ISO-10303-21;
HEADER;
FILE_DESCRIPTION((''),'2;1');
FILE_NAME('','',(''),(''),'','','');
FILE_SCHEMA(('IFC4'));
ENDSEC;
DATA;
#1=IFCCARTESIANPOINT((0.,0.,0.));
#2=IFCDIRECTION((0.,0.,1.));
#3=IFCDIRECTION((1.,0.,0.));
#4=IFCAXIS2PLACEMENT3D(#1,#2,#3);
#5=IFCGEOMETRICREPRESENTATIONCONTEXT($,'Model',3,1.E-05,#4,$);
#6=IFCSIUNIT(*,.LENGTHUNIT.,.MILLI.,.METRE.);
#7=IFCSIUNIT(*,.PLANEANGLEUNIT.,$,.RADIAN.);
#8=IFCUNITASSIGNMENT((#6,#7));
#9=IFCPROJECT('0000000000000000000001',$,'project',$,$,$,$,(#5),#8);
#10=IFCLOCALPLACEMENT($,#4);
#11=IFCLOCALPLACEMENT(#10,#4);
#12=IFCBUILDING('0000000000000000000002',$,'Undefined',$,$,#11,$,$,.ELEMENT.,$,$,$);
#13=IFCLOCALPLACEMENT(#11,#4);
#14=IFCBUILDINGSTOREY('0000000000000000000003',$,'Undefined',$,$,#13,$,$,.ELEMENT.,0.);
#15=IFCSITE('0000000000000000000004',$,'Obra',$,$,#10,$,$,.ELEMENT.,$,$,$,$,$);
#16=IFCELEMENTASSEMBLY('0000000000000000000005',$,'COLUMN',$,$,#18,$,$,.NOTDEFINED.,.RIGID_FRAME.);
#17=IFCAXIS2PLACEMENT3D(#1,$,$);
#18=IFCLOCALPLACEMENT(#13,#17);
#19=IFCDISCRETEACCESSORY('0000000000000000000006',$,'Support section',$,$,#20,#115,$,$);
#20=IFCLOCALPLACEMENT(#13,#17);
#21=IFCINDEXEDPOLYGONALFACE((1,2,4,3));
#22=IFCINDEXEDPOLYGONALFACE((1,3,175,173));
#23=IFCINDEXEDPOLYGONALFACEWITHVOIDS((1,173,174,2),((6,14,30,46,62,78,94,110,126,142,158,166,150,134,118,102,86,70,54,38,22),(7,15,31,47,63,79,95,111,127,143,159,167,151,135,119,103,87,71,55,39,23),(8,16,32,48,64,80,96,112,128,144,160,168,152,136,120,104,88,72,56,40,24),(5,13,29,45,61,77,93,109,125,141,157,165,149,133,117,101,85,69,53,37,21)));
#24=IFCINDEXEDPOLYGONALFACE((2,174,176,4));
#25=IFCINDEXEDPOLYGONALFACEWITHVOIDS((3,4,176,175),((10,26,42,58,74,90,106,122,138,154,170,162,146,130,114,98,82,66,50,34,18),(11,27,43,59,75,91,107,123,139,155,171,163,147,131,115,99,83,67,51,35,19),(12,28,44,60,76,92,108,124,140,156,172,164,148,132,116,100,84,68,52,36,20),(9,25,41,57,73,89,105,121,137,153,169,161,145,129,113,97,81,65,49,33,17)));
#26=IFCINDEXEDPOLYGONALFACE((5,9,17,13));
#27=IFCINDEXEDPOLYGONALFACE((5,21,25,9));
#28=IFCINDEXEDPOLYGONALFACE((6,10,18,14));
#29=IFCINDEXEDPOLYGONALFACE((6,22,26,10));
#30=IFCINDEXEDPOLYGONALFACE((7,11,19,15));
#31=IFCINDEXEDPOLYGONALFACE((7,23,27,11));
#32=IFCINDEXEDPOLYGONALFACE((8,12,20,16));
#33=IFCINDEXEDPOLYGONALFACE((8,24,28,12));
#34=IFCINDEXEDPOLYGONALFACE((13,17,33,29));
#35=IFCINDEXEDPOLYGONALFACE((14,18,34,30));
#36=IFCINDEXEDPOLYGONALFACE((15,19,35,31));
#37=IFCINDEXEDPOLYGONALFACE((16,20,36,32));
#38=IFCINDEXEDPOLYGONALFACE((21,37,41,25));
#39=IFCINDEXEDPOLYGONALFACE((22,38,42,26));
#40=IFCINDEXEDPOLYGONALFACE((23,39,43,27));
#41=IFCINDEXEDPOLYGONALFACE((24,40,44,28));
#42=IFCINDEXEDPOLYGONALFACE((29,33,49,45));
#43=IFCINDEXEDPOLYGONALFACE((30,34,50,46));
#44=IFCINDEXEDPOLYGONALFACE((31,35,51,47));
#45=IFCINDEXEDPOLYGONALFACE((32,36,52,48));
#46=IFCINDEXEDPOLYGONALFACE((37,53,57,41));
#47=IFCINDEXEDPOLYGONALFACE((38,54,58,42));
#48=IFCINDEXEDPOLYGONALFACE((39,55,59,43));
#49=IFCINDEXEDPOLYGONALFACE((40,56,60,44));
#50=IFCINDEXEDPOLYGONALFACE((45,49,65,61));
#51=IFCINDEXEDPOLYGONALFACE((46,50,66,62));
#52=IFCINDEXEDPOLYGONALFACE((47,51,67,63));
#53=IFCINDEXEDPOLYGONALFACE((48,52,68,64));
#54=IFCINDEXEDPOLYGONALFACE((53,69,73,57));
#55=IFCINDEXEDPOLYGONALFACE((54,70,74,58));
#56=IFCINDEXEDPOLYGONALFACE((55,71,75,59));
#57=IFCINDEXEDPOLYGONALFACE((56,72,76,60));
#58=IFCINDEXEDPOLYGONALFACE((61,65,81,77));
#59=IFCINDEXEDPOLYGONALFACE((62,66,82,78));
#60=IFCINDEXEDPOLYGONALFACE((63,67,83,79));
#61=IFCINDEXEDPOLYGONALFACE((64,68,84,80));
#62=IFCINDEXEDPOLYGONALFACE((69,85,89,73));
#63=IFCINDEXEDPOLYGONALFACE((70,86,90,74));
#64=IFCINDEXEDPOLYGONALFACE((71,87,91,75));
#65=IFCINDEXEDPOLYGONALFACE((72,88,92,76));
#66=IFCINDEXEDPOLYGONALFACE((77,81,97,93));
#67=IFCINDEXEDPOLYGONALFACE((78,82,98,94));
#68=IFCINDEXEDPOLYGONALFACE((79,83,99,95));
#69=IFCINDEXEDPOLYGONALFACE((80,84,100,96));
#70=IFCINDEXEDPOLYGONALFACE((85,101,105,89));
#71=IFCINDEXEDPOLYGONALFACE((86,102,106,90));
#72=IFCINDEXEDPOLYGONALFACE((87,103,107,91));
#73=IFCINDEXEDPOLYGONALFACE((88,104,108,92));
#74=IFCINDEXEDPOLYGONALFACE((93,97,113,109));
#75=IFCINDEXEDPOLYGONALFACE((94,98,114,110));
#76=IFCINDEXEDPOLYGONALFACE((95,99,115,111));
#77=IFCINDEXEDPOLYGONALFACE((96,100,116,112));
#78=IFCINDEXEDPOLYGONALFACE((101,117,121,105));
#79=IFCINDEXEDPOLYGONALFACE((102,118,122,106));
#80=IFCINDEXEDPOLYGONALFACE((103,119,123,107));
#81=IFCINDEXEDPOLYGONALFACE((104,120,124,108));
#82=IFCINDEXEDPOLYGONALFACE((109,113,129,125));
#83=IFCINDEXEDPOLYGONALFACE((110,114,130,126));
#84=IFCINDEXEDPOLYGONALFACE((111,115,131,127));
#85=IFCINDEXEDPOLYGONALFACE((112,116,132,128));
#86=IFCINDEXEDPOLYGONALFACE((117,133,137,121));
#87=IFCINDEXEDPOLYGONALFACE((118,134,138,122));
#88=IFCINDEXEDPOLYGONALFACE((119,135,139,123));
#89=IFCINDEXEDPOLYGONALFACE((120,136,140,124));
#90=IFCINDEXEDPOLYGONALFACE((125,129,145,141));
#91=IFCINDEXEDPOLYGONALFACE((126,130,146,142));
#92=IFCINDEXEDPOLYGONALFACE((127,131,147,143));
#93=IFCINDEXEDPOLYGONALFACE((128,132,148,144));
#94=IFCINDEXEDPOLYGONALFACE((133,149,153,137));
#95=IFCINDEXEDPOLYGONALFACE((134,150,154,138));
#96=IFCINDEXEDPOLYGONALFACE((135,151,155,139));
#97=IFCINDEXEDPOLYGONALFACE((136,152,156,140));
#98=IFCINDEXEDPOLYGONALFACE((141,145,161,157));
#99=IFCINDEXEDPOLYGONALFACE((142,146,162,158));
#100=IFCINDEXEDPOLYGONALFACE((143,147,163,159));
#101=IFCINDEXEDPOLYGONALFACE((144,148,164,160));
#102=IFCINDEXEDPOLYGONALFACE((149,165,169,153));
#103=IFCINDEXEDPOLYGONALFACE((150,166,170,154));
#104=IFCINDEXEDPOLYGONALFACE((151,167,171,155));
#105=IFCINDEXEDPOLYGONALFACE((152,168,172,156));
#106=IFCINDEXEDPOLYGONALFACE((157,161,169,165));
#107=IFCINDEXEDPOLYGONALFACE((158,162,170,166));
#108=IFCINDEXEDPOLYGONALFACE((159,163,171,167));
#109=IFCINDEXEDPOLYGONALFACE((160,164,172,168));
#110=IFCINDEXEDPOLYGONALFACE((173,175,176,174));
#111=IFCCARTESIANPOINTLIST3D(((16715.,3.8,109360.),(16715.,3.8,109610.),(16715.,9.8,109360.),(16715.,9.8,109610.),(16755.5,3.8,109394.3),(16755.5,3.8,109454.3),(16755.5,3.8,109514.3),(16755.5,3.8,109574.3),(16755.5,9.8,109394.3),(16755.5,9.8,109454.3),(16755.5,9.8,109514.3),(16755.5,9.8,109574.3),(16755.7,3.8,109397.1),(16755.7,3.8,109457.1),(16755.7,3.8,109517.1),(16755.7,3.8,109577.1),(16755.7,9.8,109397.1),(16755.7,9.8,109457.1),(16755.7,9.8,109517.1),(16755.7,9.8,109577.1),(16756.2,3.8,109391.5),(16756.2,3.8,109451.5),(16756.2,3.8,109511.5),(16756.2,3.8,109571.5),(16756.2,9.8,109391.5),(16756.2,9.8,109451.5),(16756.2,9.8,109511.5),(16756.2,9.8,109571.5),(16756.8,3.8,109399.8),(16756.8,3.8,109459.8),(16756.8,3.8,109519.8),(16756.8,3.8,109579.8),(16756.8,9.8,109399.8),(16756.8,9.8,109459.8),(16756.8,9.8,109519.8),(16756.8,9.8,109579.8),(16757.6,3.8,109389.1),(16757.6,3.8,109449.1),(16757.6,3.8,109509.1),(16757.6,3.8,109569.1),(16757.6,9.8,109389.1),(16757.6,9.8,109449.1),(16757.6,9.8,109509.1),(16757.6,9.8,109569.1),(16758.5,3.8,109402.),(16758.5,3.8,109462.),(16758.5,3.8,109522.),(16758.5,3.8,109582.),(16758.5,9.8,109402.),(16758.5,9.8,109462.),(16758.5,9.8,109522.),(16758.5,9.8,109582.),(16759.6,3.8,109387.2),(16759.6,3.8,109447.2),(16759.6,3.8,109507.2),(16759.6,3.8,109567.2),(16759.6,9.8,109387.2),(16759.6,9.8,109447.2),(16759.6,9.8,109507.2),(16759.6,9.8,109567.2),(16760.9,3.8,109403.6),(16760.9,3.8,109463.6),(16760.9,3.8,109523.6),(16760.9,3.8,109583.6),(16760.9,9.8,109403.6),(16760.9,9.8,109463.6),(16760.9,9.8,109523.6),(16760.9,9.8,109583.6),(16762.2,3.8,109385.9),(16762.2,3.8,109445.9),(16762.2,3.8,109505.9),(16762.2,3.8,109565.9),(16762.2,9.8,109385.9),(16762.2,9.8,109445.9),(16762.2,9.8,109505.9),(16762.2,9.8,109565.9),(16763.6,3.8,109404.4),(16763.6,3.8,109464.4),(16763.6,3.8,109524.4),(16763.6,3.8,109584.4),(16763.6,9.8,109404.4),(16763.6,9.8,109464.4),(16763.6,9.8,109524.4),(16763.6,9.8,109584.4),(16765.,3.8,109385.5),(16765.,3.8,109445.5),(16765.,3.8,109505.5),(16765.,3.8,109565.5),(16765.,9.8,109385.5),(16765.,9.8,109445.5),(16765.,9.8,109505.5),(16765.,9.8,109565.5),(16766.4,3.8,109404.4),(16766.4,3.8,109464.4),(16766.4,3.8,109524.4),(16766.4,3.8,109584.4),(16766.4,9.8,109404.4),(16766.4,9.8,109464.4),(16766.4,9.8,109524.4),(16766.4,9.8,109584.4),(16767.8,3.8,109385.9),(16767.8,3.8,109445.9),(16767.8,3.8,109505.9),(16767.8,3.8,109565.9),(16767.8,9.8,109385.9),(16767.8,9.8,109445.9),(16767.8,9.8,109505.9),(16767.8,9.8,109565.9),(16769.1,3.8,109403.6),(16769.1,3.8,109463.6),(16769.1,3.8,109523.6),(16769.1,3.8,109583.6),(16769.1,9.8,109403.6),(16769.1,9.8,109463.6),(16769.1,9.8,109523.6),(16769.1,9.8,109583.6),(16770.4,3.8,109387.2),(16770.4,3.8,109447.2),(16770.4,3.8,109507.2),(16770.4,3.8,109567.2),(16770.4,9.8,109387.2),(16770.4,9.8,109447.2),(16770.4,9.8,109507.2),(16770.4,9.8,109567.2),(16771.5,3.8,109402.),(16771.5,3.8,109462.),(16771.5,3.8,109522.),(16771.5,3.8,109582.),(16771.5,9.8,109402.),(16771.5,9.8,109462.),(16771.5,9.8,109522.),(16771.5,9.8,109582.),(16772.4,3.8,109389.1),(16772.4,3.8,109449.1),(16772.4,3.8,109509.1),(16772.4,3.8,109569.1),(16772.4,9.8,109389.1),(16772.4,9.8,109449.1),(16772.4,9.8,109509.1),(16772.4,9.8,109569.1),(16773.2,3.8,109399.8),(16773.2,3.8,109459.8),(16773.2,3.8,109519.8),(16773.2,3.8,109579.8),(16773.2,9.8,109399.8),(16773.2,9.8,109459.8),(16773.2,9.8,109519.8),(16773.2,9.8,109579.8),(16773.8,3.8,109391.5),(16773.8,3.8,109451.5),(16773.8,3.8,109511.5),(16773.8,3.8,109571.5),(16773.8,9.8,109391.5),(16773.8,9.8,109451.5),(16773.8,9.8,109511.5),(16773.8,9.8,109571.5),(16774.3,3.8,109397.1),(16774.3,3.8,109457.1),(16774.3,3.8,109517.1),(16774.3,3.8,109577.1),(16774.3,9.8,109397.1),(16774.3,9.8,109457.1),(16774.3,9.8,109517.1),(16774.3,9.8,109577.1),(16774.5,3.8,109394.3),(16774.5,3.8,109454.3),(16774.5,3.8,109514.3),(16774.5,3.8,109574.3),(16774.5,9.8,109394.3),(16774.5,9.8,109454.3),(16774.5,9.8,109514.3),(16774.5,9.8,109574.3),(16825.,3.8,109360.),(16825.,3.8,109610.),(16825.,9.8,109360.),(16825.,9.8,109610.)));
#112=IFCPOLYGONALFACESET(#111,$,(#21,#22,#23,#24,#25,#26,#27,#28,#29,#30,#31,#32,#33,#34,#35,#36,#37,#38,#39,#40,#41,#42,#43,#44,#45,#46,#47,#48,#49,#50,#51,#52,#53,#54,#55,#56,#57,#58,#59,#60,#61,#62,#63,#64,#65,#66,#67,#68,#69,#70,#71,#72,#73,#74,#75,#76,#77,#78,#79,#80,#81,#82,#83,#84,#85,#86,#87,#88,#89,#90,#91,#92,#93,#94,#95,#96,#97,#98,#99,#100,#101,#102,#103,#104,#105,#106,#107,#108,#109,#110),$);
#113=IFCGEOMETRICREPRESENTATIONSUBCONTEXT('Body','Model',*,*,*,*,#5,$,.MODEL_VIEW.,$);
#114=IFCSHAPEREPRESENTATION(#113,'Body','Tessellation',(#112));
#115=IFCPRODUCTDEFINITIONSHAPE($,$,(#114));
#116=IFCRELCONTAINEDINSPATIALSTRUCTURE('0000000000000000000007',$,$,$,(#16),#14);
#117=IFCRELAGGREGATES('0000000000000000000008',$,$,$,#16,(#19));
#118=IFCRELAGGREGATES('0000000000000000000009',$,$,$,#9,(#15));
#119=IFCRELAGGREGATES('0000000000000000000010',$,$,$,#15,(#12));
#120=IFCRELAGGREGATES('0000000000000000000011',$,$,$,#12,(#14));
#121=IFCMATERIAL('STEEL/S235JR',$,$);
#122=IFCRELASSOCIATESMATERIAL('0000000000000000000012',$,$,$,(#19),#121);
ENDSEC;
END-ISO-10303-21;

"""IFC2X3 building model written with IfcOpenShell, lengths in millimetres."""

from ifc_helpers import new_model, si_unit, frame, origin_with_axes, origin_2d_with_axis, place, context, subcontext, project, spatial, rectangle, circle, extrude, source, transform, mapped, material, element, aggregate, save


model = new_model("IFC2X3")

# Units and contexts
model_context = context("Model", 3, precision=1e-05, world=origin_with_axes())
body_context = subcontext(model_context, "Body", "Model", "MODEL_VIEW")
ifc_project = project(units=[si_unit("LENGTHUNIT", "METRE", prefix="MILLI"), si_unit("PLANEANGLEUNIT", "RADIAN")], contexts=[model_context])

# Site, building, storey
site_placement = place(None, origin_with_axes())
site = spatial("IfcSite", under=ifc_project, at=site_placement, Name="Obra", CompositionType="ELEMENT")
building_placement = place(site_placement, origin_with_axes())
building = spatial("IfcBuilding", under=site, at=building_placement, Name="Undefined", CompositionType="ELEMENT")
storey_placement = place(building_placement, origin_with_axes())
storey = spatial("IfcBuildingStorey", under=building, at=storey_placement, Name="Undefined", CompositionType="ELEMENT", Elevation=0.0)

# Element assembly, discrete accessory, opening
assembly_1_placement = place(storey_placement, origin_with_axes())
assembly_1 = element("IfcElementAssembly", 1, at=assembly_1_placement, inside=storey, Name="COLUMN", AssemblyPlace="NOTDEFINED", PredefinedType="RIGID_FRAME")
ifc_material_1 = material(Name="STEEL/S235JR")
shared_shape_1 = source(origin_with_axes(), body_context, "Body", "SweptSolid", [
    extrude(circle(Radius=9.5, at=origin_2d_with_axis()), frame((0.0, -9.8, 0.0), z_axis=(0.0, 1.0, 0.0), x_axis=(1.0, 0.0, 0.0)), (0.0, 0.0, 1.0), 6.2),
])
discrete_accessory_1_placement = place(assembly_1_placement, frame((16770.0, 6.8, 109360.0), z_axis=(0.0, 0.0, 1.0), x_axis=(1.0, 0.0, 0.0)))
discrete_accessory_1 = element("IfcDiscreteAccessory", 2, at=discrete_accessory_1_placement, material=ifc_material_1, Name="Support section", context=body_context, shape_type="SweptSolid", body=[
    extrude(rectangle(XDim=6.0, YDim=110.0, at=origin_2d_with_axis()), frame((0.0, 0.0, 250.0), z_axis=(0.0, 0.0, -1.0), x_axis=(0.0, 1.0, 0.0)), (0.0, 0.0, 1.0), 250.0),
])
opening_1_placement = place(assembly_1_placement, frame((16815.0, 0.0, 109650.0), z_axis=(-1.0, 0.0, 0.0), x_axis=(0.0, 0.0, -1.0)))
element("IfcOpeningElement", 3, at=opening_1_placement, cuts=discrete_accessory_1, ObjectType="Opening", context=body_context, shape_type="MappedRepresentation", body=[
    mapped(shared_shape_1, transform((75.0, 0.0, 50.0))),
    mapped(shared_shape_1, transform((135.0, 0.0, 50.0))),
    mapped(shared_shape_1, transform((195.0, 0.0, 50.0))),
    mapped(shared_shape_1, transform((255.0, 0.0, 50.0))),
])
aggregate(assembly_1, [discrete_accessory_1])

save(model, "model.ifc")
